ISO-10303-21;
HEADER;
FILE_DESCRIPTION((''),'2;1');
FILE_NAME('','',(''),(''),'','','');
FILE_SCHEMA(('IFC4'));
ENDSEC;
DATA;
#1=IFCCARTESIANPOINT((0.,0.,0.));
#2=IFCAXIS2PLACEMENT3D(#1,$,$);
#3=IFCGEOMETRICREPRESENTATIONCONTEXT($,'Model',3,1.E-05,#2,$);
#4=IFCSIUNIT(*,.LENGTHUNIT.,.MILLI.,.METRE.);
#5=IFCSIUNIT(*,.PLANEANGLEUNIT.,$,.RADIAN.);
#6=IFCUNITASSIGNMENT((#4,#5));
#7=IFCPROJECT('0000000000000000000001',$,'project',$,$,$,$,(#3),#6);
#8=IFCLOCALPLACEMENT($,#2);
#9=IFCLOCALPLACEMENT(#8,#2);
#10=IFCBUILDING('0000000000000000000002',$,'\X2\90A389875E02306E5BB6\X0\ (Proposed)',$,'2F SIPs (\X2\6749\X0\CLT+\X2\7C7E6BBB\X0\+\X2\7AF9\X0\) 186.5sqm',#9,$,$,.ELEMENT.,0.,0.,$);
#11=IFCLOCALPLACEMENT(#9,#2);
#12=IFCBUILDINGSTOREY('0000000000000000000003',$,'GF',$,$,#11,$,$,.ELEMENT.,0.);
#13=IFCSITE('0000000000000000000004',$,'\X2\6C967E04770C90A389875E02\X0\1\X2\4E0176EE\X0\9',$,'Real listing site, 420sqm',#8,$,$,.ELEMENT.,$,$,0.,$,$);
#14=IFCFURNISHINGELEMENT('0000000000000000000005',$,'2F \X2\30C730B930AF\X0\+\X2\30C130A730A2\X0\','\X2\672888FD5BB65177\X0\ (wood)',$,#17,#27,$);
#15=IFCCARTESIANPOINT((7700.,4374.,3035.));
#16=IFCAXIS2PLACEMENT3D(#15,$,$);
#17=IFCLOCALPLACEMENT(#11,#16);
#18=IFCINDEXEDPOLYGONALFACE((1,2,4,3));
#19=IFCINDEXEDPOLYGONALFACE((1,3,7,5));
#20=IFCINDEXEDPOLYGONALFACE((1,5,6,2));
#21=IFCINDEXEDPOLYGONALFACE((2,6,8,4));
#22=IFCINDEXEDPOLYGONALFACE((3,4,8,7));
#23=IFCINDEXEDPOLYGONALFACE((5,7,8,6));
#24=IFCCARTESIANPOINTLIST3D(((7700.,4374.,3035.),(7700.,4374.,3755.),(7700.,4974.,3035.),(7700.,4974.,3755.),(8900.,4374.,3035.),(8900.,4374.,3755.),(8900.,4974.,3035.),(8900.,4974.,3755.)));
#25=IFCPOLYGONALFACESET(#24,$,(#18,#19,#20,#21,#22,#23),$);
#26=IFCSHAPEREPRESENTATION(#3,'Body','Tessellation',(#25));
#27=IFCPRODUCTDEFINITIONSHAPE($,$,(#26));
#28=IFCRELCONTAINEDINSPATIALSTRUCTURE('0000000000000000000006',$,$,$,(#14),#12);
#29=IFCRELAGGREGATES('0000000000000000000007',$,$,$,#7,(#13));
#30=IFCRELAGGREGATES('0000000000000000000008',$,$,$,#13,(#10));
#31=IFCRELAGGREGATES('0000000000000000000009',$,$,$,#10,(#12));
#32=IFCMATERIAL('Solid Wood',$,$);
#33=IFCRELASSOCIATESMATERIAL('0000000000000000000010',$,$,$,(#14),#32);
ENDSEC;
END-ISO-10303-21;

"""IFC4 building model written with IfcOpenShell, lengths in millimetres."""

from ifc_helpers import new_model, si_unit, frame, frame_2d, origin, place, context, project, spatial, rectangle, extrude, material, element, save


model = new_model("IFC4")

# Units and contexts
model_context = context("Model", 3, precision=1e-05, world=origin())
ifc_project = project(units=[si_unit("LENGTHUNIT", "METRE", prefix="MILLI"), si_unit("PLANEANGLEUNIT", "RADIAN")], contexts=[model_context])

# Site, building, storey
site_placement = place(None, origin())
site = spatial("IfcSite", under=ifc_project, at=site_placement, Name="沖縄県那覇市1丁目9", ObjectType="Real listing site, 420sqm", CompositionType="ELEMENT", RefElevation=0.0)
building_placement = place(site_placement, origin())
building = spatial("IfcBuilding", under=site, at=building_placement, Name="那覇市の家 (Proposed)", ObjectType="2F SIPs (杉CLT+籾殻+竹) 186.5sqm", CompositionType="ELEMENT", ElevationOfRefHeight=0.0, ElevationOfTerrain=0.0)
storey_placement = place(building_placement, origin())
storey = spatial("IfcBuildingStorey", under=building, at=storey_placement, Name="GF", CompositionType="ELEMENT", Elevation=0.0)

# Shared definitions
ifc_material_1 = material(Name="Solid Wood")

# Furnishing element
furnishing_1_placement = place(storey_placement, frame((7700.0, 4374.0, 3035.0)))
element("IfcFurnishingElement", 1, at=furnishing_1_placement, inside=storey, material=ifc_material_1, Name="2F デスク+チェア", Description="木製家具 (wood)", context=model_context, shape_type="SweptSolid", body=[
    extrude(rectangle(XDim=1200.0, YDim=600.0, at=frame_2d((600.0, 300.0))), frame((7700.0, 4374.0, 3035.0)), (0.0, 0.0, 1.0), 720.0),
])

save(model, "model.ifc")
